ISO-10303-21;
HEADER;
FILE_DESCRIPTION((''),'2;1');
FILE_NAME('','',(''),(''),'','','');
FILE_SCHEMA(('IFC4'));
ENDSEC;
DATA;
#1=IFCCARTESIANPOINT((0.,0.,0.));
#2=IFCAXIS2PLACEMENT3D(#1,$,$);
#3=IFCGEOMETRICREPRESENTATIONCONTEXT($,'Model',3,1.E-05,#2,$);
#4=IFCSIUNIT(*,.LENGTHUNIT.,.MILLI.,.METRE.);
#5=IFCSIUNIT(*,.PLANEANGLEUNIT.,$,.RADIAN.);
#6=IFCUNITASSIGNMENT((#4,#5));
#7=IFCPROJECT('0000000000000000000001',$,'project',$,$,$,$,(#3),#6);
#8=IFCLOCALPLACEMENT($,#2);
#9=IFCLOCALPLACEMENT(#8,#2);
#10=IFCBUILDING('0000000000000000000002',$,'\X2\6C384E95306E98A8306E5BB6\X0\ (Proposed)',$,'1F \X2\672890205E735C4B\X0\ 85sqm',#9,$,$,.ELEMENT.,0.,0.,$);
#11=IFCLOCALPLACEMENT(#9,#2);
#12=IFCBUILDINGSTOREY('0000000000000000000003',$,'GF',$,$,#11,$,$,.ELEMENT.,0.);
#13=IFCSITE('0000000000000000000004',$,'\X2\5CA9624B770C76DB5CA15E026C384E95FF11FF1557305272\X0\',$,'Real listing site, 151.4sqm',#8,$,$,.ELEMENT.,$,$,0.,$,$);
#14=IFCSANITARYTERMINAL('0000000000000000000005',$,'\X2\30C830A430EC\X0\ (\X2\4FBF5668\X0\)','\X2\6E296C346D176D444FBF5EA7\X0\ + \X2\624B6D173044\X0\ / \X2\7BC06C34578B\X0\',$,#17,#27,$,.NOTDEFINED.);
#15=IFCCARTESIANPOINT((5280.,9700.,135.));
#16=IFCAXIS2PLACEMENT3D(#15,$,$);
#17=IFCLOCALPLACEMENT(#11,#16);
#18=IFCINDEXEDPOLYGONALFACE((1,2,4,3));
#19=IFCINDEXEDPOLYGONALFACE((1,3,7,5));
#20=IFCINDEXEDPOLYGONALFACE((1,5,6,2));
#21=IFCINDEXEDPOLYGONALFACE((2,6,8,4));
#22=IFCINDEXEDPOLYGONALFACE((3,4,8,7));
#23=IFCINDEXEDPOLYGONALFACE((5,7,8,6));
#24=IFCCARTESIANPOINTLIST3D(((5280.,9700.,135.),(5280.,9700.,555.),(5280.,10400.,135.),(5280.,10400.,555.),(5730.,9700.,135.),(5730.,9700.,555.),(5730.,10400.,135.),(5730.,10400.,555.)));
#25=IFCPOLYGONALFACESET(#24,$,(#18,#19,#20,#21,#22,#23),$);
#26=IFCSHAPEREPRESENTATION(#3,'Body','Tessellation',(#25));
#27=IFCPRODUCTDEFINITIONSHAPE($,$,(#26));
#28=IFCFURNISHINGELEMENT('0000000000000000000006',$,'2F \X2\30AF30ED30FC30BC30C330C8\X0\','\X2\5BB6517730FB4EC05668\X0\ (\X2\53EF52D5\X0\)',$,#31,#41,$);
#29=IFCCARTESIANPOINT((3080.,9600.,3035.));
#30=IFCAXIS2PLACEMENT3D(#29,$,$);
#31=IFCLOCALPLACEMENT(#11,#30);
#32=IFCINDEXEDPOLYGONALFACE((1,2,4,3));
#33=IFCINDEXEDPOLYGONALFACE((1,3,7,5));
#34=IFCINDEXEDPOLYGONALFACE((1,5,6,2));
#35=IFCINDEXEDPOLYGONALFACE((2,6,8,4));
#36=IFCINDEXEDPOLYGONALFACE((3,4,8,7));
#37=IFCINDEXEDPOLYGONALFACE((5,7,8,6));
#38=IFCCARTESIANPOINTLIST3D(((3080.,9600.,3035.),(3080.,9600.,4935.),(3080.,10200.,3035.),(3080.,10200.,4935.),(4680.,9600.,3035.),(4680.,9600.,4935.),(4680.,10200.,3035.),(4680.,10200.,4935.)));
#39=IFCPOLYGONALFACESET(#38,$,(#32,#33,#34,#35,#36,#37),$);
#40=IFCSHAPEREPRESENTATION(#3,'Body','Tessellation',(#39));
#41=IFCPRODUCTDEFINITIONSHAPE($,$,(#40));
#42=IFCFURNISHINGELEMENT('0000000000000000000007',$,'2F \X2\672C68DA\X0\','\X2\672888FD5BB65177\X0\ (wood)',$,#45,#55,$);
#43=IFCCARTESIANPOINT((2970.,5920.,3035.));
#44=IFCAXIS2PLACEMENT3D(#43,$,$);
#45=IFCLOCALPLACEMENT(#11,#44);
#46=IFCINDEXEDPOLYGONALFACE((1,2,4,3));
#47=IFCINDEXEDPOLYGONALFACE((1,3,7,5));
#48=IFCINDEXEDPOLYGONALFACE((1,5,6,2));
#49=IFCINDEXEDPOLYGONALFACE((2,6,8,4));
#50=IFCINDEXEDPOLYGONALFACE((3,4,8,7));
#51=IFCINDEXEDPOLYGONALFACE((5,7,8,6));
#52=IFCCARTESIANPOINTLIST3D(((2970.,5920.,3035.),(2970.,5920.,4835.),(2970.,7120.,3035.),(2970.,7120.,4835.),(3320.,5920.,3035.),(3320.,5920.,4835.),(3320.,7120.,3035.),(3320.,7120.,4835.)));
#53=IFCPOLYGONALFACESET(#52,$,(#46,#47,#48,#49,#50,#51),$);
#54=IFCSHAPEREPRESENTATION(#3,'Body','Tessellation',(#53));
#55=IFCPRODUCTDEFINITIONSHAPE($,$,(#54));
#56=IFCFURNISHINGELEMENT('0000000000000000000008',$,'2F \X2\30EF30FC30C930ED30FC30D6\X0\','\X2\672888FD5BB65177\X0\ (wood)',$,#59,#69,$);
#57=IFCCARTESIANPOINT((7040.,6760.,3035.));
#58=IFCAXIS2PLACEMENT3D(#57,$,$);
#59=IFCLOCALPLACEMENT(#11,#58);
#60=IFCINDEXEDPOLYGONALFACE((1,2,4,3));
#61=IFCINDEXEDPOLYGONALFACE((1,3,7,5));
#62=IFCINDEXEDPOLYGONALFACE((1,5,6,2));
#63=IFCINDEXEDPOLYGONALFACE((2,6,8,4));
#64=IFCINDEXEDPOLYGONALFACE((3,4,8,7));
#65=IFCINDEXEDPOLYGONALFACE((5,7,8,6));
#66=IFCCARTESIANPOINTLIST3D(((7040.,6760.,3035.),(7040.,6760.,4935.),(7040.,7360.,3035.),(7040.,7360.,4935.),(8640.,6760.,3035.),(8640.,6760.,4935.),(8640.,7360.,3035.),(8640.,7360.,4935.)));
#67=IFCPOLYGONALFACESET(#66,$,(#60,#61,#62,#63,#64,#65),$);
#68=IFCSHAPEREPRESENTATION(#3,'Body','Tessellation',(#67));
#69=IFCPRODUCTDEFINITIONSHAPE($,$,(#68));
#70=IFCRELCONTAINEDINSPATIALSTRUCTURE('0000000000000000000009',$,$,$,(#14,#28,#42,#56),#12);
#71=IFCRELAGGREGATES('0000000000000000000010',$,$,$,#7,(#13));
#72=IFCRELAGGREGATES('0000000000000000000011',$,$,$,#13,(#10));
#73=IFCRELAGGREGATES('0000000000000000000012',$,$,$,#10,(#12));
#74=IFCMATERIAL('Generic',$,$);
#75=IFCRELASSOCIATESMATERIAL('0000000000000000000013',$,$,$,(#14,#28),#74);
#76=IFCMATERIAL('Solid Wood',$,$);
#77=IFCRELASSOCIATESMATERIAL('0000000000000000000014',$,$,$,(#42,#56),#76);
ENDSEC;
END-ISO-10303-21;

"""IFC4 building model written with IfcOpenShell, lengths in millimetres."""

from ifc_helpers import new_model, si_unit, frame, frame_2d, origin, place, context, project, spatial, rectangle, extrude, material, element, save


model = new_model("IFC4")

# Units and contexts
model_context = context("Model", 3, precision=1e-05, world=origin())
ifc_project = project(units=[si_unit("LENGTHUNIT", "METRE", prefix="MILLI"), si_unit("PLANEANGLEUNIT", "RADIAN")], contexts=[model_context])

# Site, building, storey
site_placement = place(None, origin())
site = spatial("IfcSite", under=ifc_project, at=site_placement, Name="岩手県盛岡市永井１５地割", ObjectType="Real listing site, 151.4sqm", CompositionType="ELEMENT", RefElevation=0.0)
building_placement = place(site_placement, origin())
building = spatial("IfcBuilding", under=site, at=building_placement, Name="永井の風の家 (Proposed)", ObjectType="1F 木造平屋 85sqm", CompositionType="ELEMENT", ElevationOfRefHeight=0.0, ElevationOfTerrain=0.0)
storey_placement = place(building_placement, origin())
storey = spatial("IfcBuildingStorey", under=building, at=storey_placement, Name="GF", CompositionType="ELEMENT", Elevation=0.0)

# Shared definitions
ifc_material_1 = material(Name="Solid Wood")

# Shared definitions
ifc_material_2 = material(Name="Generic")

# Sanitary terminal
sanitary_terminal_placement = place(storey_placement, frame((5280.0, 9700.0, 135.0)))
element("IfcSanitaryTerminal", 1, at=sanitary_terminal_placement, inside=storey, material=ifc_material_2, Name="トイレ (便器)", Description="温水洗浄便座 + 手洗い / 節水型", PredefinedType="NOTDEFINED", context=model_context, shape_type="SweptSolid", body=[
    extrude(rectangle(XDim=450.0, YDim=700.0, at=frame_2d((225.0, 350.0))), frame((5280.0, 9700.0, 135.0)), (0.0, 0.0, 1.0), 420.0),
])

# Furnishing elements
furnishing_1_placement = place(storey_placement, frame((3080.0, 9600.0, 3035.0)))
element("IfcFurnishingElement", 2, at=furnishing_1_placement, inside=storey, material=ifc_material_2, Name="2F クローゼット", Description="家具・什器 (可動)", context=model_context, shape_type="SweptSolid", body=[
    extrude(rectangle(XDim=1600.0, YDim=600.0, at=frame_2d((800.0, 300.0))), frame((3080.0, 9600.0, 3035.0)), (0.0, 0.0, 1.0), 1900.0),
])
furnishing_2_placement = place(storey_placement, frame((2970.0, 5920.0, 3035.0)))
element("IfcFurnishingElement", 3, at=furnishing_2_placement, inside=storey, material=ifc_material_1, Name="2F 本棚", Description="木製家具 (wood)", context=model_context, shape_type="SweptSolid", body=[
    extrude(rectangle(XDim=350.0, YDim=1200.0, at=frame_2d((175.0, 600.0))), frame((2970.0, 5920.0, 3035.0)), (0.0, 0.0, 1.0), 1800.0),
])
furnishing_3_placement = place(storey_placement, frame((7040.0, 6760.0, 3035.0)))
element("IfcFurnishingElement", 4, at=furnishing_3_placement, inside=storey, material=ifc_material_1, Name="2F ワードローブ", Description="木製家具 (wood)", context=model_context, shape_type="SweptSolid", body=[
    extrude(rectangle(XDim=1600.0, YDim=600.0, at=frame_2d((800.0, 300.0))), frame((7040.0, 6760.0, 3035.0)), (0.0, 0.0, 1.0), 1900.0),
])

save(model, "model.ifc")
